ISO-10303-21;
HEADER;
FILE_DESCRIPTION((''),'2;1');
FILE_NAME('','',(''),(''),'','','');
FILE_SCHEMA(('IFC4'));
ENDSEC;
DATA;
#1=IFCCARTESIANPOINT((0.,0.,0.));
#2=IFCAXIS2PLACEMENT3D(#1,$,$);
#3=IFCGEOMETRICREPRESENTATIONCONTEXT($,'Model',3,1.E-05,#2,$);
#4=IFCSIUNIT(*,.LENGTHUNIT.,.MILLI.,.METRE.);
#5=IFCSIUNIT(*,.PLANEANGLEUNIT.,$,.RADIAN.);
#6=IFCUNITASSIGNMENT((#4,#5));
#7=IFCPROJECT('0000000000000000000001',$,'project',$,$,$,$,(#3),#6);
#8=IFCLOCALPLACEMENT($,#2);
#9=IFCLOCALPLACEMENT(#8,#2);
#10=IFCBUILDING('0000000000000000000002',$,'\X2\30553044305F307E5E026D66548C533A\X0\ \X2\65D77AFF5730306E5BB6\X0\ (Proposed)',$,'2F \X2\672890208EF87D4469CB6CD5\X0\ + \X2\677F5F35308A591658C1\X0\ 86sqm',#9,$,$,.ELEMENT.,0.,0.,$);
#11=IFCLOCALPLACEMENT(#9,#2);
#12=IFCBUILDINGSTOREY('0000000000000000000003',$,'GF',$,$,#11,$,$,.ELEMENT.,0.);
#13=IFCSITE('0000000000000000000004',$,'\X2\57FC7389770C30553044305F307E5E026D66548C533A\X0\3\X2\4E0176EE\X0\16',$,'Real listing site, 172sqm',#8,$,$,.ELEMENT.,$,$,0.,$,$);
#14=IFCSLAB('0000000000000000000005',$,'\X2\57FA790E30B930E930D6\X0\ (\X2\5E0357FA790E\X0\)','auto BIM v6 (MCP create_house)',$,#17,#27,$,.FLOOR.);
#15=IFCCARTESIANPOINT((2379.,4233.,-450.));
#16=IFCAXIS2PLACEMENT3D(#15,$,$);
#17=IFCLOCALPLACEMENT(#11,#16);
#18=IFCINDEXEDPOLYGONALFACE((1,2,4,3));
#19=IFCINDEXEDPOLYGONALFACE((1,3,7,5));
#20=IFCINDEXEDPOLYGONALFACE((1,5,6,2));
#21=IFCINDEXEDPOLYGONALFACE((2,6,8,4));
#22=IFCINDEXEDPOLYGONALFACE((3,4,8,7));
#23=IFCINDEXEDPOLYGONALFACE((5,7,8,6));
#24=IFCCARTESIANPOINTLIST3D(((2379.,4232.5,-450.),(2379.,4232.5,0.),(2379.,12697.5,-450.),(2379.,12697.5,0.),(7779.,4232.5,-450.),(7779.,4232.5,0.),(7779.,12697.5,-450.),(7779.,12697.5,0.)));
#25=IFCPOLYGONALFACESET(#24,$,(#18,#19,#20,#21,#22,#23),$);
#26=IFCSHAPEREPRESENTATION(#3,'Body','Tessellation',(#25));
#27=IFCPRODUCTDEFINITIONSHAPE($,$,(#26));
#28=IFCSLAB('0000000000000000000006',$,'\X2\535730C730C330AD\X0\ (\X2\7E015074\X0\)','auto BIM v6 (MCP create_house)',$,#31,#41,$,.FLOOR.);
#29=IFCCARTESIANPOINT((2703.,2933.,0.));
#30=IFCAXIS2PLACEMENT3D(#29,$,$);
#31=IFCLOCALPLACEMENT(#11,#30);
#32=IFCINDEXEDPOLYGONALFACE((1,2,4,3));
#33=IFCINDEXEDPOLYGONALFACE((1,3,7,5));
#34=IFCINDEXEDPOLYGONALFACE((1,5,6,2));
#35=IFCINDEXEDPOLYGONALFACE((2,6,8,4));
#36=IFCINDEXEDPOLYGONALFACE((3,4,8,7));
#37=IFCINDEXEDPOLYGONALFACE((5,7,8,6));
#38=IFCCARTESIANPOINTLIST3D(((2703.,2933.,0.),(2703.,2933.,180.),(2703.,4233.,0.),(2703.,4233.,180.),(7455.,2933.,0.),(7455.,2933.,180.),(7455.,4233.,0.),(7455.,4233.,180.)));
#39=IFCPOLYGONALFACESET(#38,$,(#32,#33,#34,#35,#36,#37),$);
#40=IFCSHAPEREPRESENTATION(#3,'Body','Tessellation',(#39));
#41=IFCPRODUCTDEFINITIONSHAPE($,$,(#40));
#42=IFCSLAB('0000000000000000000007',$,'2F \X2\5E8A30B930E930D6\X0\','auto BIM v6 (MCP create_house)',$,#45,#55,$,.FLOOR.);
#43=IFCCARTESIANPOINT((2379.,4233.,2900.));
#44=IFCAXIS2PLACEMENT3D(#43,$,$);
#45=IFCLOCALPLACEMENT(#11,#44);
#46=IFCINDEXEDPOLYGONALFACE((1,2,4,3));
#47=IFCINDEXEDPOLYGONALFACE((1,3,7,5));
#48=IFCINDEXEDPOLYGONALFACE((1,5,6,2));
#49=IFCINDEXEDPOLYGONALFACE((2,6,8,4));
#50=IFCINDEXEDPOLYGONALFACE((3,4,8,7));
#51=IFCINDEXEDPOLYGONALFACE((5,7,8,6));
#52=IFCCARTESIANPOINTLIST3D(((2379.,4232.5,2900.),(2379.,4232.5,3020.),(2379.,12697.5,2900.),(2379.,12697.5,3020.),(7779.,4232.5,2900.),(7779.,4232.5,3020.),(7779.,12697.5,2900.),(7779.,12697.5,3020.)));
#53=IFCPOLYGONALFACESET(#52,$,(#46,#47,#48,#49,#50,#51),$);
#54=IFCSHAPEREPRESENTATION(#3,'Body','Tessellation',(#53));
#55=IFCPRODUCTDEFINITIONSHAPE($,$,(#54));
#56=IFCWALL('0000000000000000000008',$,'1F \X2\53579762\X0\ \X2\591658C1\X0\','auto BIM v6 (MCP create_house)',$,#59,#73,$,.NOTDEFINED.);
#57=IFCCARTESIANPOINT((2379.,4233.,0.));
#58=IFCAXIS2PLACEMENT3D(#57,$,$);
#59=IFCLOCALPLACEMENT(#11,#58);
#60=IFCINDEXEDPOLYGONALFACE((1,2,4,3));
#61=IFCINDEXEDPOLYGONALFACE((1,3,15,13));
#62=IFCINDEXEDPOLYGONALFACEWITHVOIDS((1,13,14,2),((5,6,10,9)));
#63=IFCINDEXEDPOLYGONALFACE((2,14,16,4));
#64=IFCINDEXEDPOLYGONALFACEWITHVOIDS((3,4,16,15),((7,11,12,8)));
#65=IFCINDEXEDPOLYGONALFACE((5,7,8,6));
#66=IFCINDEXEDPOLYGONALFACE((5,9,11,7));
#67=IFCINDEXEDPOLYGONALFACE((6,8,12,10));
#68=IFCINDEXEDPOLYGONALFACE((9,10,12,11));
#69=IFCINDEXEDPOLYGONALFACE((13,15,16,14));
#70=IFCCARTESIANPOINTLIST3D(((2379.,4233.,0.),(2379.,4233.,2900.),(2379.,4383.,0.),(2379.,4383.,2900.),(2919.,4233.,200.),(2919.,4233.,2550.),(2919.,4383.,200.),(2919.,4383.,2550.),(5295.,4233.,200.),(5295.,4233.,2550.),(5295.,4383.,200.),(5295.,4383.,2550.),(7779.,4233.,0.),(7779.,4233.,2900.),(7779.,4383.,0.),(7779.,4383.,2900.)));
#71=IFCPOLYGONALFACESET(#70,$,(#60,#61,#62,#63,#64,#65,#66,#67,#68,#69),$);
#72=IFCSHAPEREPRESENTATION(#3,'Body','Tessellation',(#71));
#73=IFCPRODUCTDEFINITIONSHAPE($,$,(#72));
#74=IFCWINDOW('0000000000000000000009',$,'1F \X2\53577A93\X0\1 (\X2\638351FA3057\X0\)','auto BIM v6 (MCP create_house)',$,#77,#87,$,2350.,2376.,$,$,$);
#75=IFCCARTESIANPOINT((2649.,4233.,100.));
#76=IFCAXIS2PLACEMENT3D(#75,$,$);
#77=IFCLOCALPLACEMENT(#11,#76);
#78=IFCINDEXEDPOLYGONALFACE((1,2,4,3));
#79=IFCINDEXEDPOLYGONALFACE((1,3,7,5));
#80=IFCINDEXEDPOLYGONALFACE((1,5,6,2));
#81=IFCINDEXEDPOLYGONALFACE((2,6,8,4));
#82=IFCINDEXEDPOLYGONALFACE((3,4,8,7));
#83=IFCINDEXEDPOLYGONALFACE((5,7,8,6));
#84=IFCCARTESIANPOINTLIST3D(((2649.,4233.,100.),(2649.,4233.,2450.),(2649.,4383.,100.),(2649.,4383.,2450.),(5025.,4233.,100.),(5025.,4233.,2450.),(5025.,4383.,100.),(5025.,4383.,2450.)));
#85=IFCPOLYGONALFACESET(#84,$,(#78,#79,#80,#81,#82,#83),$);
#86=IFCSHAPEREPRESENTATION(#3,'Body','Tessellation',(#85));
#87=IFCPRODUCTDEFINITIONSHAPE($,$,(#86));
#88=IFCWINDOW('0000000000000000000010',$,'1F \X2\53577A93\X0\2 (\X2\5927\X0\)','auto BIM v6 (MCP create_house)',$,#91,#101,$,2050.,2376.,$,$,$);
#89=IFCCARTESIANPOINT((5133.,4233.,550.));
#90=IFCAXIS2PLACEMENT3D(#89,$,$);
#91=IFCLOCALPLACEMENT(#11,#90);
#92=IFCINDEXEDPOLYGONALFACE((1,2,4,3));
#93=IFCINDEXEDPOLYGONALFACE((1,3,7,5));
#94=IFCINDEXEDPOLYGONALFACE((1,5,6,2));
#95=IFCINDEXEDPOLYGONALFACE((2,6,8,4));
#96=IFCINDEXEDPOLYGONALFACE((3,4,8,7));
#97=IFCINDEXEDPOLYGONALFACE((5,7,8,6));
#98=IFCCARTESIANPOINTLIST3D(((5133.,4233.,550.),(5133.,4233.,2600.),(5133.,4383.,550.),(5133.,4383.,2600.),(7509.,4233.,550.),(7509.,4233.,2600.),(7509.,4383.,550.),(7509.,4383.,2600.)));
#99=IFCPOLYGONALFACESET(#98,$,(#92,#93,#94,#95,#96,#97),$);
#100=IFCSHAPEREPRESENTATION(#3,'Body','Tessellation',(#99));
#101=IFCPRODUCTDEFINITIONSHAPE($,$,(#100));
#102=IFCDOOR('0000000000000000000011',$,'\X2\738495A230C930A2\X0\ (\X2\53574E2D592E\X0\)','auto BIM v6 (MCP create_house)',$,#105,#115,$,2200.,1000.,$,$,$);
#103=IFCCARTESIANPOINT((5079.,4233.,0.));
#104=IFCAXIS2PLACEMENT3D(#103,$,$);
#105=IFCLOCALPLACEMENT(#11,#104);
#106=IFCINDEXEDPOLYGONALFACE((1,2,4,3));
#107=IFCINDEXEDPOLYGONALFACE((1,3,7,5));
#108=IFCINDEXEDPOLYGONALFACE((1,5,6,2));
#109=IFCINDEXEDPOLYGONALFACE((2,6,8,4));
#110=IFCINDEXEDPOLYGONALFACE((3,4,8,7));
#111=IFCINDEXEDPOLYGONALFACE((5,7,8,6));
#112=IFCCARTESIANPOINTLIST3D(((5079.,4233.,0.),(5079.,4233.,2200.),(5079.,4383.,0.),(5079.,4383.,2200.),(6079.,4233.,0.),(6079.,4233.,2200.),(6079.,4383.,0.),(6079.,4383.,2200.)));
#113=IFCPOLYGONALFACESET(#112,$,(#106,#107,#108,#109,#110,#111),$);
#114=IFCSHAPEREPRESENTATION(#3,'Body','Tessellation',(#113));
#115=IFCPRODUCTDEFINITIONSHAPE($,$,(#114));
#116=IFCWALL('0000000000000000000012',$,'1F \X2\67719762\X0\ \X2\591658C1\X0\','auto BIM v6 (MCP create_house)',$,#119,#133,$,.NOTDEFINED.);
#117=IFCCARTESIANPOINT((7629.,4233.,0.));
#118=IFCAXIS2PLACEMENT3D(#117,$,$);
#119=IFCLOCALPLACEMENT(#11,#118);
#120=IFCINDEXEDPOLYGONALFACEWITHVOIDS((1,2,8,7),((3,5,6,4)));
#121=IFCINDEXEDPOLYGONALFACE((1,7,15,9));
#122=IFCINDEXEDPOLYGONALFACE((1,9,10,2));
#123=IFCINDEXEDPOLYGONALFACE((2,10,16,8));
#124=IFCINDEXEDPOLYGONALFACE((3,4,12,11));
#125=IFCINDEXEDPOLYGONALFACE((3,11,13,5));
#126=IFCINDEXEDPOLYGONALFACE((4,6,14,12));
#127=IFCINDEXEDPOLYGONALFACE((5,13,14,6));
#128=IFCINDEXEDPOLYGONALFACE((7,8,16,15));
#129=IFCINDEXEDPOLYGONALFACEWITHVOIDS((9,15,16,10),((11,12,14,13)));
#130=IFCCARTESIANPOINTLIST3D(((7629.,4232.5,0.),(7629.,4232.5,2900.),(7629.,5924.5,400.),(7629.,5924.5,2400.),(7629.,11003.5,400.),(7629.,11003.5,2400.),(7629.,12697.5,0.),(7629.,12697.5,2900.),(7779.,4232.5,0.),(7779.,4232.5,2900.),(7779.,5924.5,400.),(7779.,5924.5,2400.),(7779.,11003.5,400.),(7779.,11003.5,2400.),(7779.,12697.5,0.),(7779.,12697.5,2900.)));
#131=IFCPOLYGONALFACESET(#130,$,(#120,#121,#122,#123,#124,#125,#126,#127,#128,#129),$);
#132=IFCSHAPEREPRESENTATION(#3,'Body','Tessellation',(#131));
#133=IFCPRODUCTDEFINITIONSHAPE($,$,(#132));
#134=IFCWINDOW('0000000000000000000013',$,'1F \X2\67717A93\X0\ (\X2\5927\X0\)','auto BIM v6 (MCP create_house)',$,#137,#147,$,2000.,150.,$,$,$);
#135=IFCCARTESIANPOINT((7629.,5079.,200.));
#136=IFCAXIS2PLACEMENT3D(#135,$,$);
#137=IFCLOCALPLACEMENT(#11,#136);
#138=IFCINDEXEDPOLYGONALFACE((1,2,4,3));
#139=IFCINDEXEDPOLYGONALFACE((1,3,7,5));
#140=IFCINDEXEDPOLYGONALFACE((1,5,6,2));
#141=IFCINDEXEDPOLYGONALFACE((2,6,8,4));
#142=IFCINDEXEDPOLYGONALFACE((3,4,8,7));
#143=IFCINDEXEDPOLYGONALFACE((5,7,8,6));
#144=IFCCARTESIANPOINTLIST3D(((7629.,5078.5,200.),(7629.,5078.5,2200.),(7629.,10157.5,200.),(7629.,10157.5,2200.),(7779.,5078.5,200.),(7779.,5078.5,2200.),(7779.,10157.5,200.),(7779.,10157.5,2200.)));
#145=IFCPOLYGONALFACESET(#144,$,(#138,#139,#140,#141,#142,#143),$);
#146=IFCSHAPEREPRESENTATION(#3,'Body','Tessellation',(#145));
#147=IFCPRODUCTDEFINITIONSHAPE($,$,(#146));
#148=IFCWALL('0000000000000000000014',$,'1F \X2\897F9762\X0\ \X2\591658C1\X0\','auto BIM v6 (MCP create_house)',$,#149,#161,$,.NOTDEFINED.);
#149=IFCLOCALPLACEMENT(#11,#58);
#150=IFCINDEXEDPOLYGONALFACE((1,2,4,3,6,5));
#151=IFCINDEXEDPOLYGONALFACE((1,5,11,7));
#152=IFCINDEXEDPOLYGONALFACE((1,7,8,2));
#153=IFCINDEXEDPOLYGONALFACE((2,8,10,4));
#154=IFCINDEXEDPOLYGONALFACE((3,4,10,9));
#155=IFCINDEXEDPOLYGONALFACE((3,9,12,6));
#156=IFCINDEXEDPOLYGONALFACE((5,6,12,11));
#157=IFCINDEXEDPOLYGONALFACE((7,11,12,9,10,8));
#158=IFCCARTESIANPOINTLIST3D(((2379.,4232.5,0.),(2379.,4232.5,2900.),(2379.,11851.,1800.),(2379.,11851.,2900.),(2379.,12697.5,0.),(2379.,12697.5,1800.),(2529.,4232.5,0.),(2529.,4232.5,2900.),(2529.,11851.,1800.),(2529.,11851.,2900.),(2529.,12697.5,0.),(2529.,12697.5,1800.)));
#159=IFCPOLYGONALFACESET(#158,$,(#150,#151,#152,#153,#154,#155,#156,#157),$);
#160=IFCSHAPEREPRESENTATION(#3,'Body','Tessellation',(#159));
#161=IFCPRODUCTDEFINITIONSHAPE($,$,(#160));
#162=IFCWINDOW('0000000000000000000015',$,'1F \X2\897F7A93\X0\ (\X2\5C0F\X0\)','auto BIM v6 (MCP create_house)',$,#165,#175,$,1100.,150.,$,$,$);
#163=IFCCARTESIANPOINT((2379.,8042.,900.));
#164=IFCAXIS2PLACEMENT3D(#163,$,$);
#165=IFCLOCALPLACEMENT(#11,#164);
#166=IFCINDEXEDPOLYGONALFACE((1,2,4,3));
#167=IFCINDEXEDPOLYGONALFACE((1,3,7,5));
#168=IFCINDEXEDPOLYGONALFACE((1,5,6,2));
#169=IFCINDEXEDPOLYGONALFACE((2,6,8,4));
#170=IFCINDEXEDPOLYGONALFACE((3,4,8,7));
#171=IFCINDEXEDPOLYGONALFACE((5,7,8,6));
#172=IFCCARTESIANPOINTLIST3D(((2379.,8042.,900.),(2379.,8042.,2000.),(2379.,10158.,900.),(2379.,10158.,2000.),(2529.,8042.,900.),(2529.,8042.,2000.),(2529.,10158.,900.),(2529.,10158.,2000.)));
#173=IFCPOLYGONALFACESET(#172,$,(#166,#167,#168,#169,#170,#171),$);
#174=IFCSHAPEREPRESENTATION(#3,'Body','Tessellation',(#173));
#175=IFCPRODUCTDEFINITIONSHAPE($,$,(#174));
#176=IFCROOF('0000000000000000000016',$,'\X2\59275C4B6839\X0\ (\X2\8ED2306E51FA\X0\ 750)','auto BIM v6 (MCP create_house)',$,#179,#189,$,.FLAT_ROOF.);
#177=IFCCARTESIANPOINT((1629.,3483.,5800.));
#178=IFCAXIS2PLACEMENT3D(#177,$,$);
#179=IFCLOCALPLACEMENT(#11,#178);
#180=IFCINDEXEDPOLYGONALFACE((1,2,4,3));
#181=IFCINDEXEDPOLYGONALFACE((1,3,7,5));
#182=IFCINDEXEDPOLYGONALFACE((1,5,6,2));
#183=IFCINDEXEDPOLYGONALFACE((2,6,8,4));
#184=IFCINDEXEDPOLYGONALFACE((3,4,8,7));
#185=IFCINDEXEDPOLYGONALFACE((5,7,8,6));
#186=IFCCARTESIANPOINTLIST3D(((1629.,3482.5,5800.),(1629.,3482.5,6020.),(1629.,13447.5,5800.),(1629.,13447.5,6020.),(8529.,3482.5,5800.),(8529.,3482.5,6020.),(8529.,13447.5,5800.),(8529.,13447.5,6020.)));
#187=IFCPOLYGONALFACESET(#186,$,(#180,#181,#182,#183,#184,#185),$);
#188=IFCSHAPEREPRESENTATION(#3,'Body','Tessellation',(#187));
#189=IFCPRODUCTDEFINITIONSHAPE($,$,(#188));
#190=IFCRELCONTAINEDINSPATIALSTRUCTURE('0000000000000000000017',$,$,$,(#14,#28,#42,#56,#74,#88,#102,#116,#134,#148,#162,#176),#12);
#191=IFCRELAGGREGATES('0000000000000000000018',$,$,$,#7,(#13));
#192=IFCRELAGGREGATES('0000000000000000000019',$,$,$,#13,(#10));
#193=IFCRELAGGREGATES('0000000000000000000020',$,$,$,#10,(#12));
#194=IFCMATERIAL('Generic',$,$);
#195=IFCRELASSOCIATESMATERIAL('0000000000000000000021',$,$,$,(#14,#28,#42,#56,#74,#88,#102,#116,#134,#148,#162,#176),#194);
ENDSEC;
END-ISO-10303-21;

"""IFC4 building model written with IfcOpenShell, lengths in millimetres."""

from ifc_helpers import new_model, si_unit, frame, frame_2d, origin, place, context, project, spatial, rectangle, extrude, material, element, fill, save


model = new_model("IFC4")

# Units and contexts
model_context = context("Model", 3, precision=1e-05, world=origin())
ifc_project = project(units=[si_unit("LENGTHUNIT", "METRE", prefix="MILLI"), si_unit("PLANEANGLEUNIT", "RADIAN")], contexts=[model_context])

# Site, building, storey
site_placement = place(None, origin())
site = spatial("IfcSite", under=ifc_project, at=site_placement, Name="埼玉県さいたま市浦和区3丁目16", ObjectType="Real listing site, 172sqm", CompositionType="ELEMENT", RefElevation=0.0)
building_placement = place(site_placement, origin())
building = spatial("IfcBuilding", under=site, at=building_placement, Name="さいたま市浦和区 旗竿地の家 (Proposed)", ObjectType="2F 木造軸組構法 + 板張り外壁 86sqm", CompositionType="ELEMENT", ElevationOfRefHeight=0.0, ElevationOfTerrain=0.0)
storey_placement = place(building_placement, origin())
storey = spatial("IfcBuildingStorey", under=building, at=storey_placement, Name="GF", CompositionType="ELEMENT", Elevation=0.0)

# Slabs
ifc_material = material(Name="Generic")
slab_1_placement = place(storey_placement, frame((2379.0, 4233.0, -450.0)))
element("IfcSlab", 1, at=slab_1_placement, inside=storey, material=ifc_material, Name="基礎スラブ (布基礎)", Description="auto BIM v6 (MCP create_house)", PredefinedType="FLOOR", context=model_context, shape_type="SweptSolid", body=[
    extrude(rectangle(XDim=5400.0, YDim=8465.0, at=frame_2d((2700.0, 4232.0))), frame((2379.0, 4233.0, -450.0)), (0.0, 0.0, 1.0), 450.0),
])
slab_2_placement = place(storey_placement, frame((2703.0, 2933.0, 0.0)))
element("IfcSlab", 2, at=slab_2_placement, inside=storey, material=ifc_material, Name="南デッキ (縁側)", Description="auto BIM v6 (MCP create_house)", PredefinedType="FLOOR", context=model_context, shape_type="SweptSolid", body=[
    extrude(rectangle(XDim=4752.0, YDim=1300.0, at=frame_2d((2376.0, 650.0))), frame((2703.0, 2933.0, 0.0)), (0.0, 0.0, 1.0), 180.0),
])
slab_3_placement = place(storey_placement, frame((2379.0, 4233.0, 2900.0)))
element("IfcSlab", 3, at=slab_3_placement, inside=storey, material=ifc_material, Name="2F 床スラブ", Description="auto BIM v6 (MCP create_house)", PredefinedType="FLOOR", context=model_context, shape_type="SweptSolid", body=[
    extrude(rectangle(XDim=5400.0, YDim=8465.0, at=frame_2d((2700.0, 4232.0))), frame((2379.0, 4233.0, 2900.0)), (0.0, 0.0, 1.0), 120.0),
])

# Wall, openings, windows, door
wall_1_placement = place(storey_placement, frame((2379.0, 4233.0, 0.0)))
wall_1 = element("IfcWall", 4, at=wall_1_placement, inside=storey, material=ifc_material, Name="1F 南面 外壁", Description="auto BIM v6 (MCP create_house)", PredefinedType="NOTDEFINED", context=model_context, shape_type="SweptSolid", body=[
    extrude(rectangle(XDim=5400.0, YDim=150.0, at=frame_2d((2700.0, 75.0))), frame((2379.0, 4233.0, 0.0)), (0.0, 0.0, 1.0), 2900.0),
])
opening_1_placement = place(storey_placement, frame((2649.0, 4233.0, 100.0)))
opening_1 = element("IfcOpeningElement", 5, at=opening_1_placement, cuts=wall_1, PredefinedType="NOTDEFINED", context=model_context, shape_type="SweptSolid", body=[
    extrude(rectangle(XDim=2376.0, YDim=150.0, at=frame_2d((1188.0, 75.0))), frame((2649.0, 4233.0, 100.0)), (0.0, 0.0, 1.0), 2350.0),
])
opening_2_placement = place(storey_placement, frame((5133.0, 4233.0, 550.0)))
opening_2 = element("IfcOpeningElement", 6, at=opening_2_placement, cuts=wall_1, PredefinedType="NOTDEFINED", context=model_context, shape_type="SweptSolid", body=[
    extrude(rectangle(XDim=2376.0, YDim=150.0, at=frame_2d((1188.0, 75.0))), frame((5133.0, 4233.0, 550.0)), (0.0, 0.0, 1.0), 2050.0),
])
opening_3_placement = place(storey_placement, frame((5079.0, 4233.0, 0.0)))
opening_3 = element("IfcOpeningElement", 7, at=opening_3_placement, cuts=wall_1, PredefinedType="NOTDEFINED", context=model_context, shape_type="SweptSolid", body=[
    extrude(rectangle(XDim=1000.0, YDim=150.0, at=frame_2d((500.0, 75.0))), frame((5079.0, 4233.0, 0.0)), (0.0, 0.0, 1.0), 2200.0),
])
window_1_placement = place(storey_placement, frame((2649.0, 4233.0, 100.0)))
window_1 = element("IfcWindow", 8, at=window_1_placement, inside=storey, material=ifc_material, Name="1F 南窓1 (掃出し)", Description="auto BIM v6 (MCP create_house)", OverallHeight=2350.0, OverallWidth=2376.0, context=model_context, shape_type="SweptSolid", body=[
    extrude(rectangle(XDim=2376.0, YDim=150.0, at=frame_2d((1188.0, 75.0))), frame((2649.0, 4233.0, 100.0)), (0.0, 0.0, 1.0), 2350.0),
])
fill(opening_1, window_1)
window_2_placement = place(storey_placement, frame((5133.0, 4233.0, 550.0)))
window_2 = element("IfcWindow", 9, at=window_2_placement, inside=storey, material=ifc_material, Name="1F 南窓2 (大)", Description="auto BIM v6 (MCP create_house)", OverallHeight=2050.0, OverallWidth=2376.0, context=model_context, shape_type="SweptSolid", body=[
    extrude(rectangle(XDim=2376.0, YDim=150.0, at=frame_2d((1188.0, 75.0))), frame((5133.0, 4233.0, 550.0)), (0.0, 0.0, 1.0), 2050.0),
])
fill(opening_2, window_2)
door_placement = place(storey_placement, frame((5079.0, 4233.0, 0.0)))
door = element("IfcDoor", 10, at=door_placement, inside=storey, material=ifc_material, Name="玄関ドア (南中央)", Description="auto BIM v6 (MCP create_house)", OverallHeight=2200.0, OverallWidth=1000.0, context=model_context, shape_type="SweptSolid", body=[
    extrude(rectangle(XDim=1000.0, YDim=150.0, at=frame_2d((500.0, 75.0))), frame((5079.0, 4233.0, 0.0)), (0.0, 0.0, 1.0), 2200.0),
])
fill(opening_3, door)

# Walls, openings, windows
wall_2_placement = place(storey_placement, frame((7629.0, 4233.0, 0.0)))
wall_2 = element("IfcWall", 11, at=wall_2_placement, inside=storey, material=ifc_material, Name="1F 東面 外壁", Description="auto BIM v6 (MCP create_house)", PredefinedType="NOTDEFINED", context=model_context, shape_type="SweptSolid", body=[
    extrude(rectangle(XDim=150.0, YDim=8465.0, at=frame_2d((75.0, 4232.0))), frame((7629.0, 4233.0, 0.0)), (0.0, 0.0, 1.0), 2900.0),
])
opening_4_placement = place(storey_placement, frame((7629.0, 5079.0, 200.0)))
opening_4 = element("IfcOpeningElement", 12, at=opening_4_placement, cuts=wall_2, PredefinedType="NOTDEFINED", context=model_context, shape_type="SweptSolid", body=[
    extrude(rectangle(XDim=150.0, YDim=5079.0, at=frame_2d((75.0, 2539.0))), frame((7629.0, 5079.0, 200.0)), (0.0, 0.0, 1.0), 2000.0),
])
window_3_placement = place(storey_placement, frame((7629.0, 5079.0, 200.0)))
window_3 = element("IfcWindow", 13, at=window_3_placement, inside=storey, material=ifc_material, Name="1F 東窓 (大)", Description="auto BIM v6 (MCP create_house)", OverallHeight=2000.0, OverallWidth=150.0, context=model_context, shape_type="SweptSolid", body=[
    extrude(rectangle(XDim=150.0, YDim=5079.0, at=frame_2d((75.0, 2539.0))), frame((7629.0, 5079.0, 200.0)), (0.0, 0.0, 1.0), 2000.0),
])
fill(opening_4, window_3)
wall_3_placement = place(storey_placement, frame((2379.0, 4233.0, 0.0)))
wall_3 = element("IfcWall", 14, at=wall_3_placement, inside=storey, material=ifc_material, Name="1F 西面 外壁", Description="auto BIM v6 (MCP create_house)", PredefinedType="NOTDEFINED", context=model_context, shape_type="SweptSolid", body=[
    extrude(rectangle(XDim=150.0, YDim=8465.0, at=frame_2d((75.0, 4232.0))), frame((2379.0, 4233.0, 0.0)), (0.0, 0.0, 1.0), 2900.0),
])
opening_5_placement = place(storey_placement, frame((2379.0, 8042.0, 900.0)))
opening_5 = element("IfcOpeningElement", 15, at=opening_5_placement, cuts=wall_3, PredefinedType="NOTDEFINED", context=model_context, shape_type="SweptSolid", body=[
    extrude(rectangle(XDim=150.0, YDim=2116.0, at=frame_2d((75.0, 1058.0))), frame((2379.0, 8042.0, 900.0)), (0.0, 0.0, 1.0), 1100.0),
])
window_4_placement = place(storey_placement, frame((2379.0, 8042.0, 900.0)))
window_4 = element("IfcWindow", 16, at=window_4_placement, inside=storey, material=ifc_material, Name="1F 西窓 (小)", Description="auto BIM v6 (MCP create_house)", OverallHeight=1100.0, OverallWidth=150.0, context=model_context, shape_type="SweptSolid", body=[
    extrude(rectangle(XDim=150.0, YDim=2116.0, at=frame_2d((75.0, 1058.0))), frame((2379.0, 8042.0, 900.0)), (0.0, 0.0, 1.0), 1100.0),
])
fill(opening_5, window_4)

# Roof
roof_placement = place(storey_placement, frame((1629.0, 3483.0, 5800.0)))
element("IfcRoof", 17, at=roof_placement, inside=storey, material=ifc_material, Name="大屋根 (軒の出 750)", Description="auto BIM v6 (MCP create_house)", PredefinedType="FLAT_ROOF", context=model_context, shape_type="SweptSolid", body=[
    extrude(rectangle(XDim=6900.0, YDim=9965.0, at=frame_2d((3450.0, 4982.0))), frame((1629.0, 3483.0, 5800.0)), (0.0, 0.0, 1.0), 220.0),
])

save(model, "model.ifc")
